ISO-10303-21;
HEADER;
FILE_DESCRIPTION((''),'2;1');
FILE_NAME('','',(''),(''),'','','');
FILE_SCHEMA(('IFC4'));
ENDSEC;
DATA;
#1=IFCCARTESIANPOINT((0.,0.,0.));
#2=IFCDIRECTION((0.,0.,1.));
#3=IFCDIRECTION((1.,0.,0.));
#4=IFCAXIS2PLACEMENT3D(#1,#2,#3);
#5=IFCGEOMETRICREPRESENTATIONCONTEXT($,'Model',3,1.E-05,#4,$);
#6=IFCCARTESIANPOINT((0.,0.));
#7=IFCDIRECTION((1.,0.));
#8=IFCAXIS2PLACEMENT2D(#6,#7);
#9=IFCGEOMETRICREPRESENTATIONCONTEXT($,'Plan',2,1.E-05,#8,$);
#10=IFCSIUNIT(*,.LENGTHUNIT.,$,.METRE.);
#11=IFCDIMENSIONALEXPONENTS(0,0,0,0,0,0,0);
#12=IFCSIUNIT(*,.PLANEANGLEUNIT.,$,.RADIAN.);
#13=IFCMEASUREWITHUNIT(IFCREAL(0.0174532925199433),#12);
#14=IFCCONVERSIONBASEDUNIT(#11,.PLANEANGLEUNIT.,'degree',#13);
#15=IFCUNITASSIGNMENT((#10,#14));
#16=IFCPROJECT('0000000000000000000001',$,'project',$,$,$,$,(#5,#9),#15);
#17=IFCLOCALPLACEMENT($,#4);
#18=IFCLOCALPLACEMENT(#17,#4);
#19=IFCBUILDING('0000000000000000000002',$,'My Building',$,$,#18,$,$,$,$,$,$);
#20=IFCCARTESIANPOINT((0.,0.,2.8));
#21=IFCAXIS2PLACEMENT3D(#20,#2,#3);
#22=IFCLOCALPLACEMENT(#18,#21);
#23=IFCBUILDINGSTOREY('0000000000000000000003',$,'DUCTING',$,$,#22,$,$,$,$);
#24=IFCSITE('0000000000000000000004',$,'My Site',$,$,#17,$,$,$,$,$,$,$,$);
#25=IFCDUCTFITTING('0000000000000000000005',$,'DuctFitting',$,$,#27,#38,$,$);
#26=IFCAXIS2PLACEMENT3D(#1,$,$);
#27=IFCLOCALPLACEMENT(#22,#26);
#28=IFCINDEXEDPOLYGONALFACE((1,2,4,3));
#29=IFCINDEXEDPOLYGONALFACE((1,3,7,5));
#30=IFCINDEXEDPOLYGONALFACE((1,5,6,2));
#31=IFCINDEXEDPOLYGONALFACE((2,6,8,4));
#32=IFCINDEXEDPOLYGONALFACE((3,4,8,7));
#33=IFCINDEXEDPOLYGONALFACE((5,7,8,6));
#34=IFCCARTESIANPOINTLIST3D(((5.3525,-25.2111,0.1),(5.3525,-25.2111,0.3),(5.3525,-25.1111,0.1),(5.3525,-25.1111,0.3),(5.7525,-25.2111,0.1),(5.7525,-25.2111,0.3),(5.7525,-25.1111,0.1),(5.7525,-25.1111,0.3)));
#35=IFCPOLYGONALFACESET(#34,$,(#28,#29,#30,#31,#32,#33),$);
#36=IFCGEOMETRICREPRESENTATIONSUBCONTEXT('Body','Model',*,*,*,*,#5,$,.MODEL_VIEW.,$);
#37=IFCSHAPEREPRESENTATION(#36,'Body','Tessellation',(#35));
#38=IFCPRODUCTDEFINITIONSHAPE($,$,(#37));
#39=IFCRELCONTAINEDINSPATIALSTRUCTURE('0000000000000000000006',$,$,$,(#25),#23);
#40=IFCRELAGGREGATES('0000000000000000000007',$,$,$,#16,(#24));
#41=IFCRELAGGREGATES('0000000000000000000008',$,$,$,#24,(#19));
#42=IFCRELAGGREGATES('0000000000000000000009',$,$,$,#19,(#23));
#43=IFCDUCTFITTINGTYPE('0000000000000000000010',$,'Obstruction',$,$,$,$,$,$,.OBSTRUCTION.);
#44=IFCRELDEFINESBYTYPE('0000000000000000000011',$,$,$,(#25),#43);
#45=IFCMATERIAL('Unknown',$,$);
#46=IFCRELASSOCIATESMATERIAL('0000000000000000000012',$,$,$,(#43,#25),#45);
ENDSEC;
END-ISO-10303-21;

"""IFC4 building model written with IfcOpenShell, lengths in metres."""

from ifc_helpers import new_model, entity, si_unit, converted_unit, frame, origin_with_axes, origin_2d_with_axis, place, context, subcontext, project, spatial, rectangle, extrude, material, material_profile, profile_set, profile_usage, type_object, element, save


model = new_model("IFC4")

# Units and contexts
model_context = context("Model", 3, precision=1e-05, world=origin_with_axes())
plan_context = context("Plan", 2, precision=1e-05, world=origin_2d_with_axis())
body_context = subcontext(model_context, "Body", "Model", "MODEL_VIEW")
ifc_project = project(units=[si_unit("LENGTHUNIT", "METRE"), converted_unit("PLANEANGLEUNIT", "degree", entity("IfcReal", 0.0174532925199433), si_unit("PLANEANGLEUNIT", "RADIAN"), dimensions=[0, 0, 0, 0, 0, 0, 0])], contexts=[model_context, plan_context])

# Site, building, storey
site_placement = place(None, origin_with_axes())
site = spatial("IfcSite", under=ifc_project, at=site_placement, Name="My Site")
building_placement = place(site_placement, origin_with_axes())
building = spatial("IfcBuilding", under=site, at=building_placement, Name="My Building")
storey_placement = place(building_placement, frame((0.0, 0.0, 2.8), z_axis=(0.0, 0.0, 1.0), x_axis=(1.0, 0.0, 0.0)))
storey = spatial("IfcBuildingStorey", under=building, at=storey_placement, Name="DUCTING")

# Shared definitions
ifc_material = material(Name="Unknown")

# Duct fitting
ifc_material_profile_1 = material_profile(ifc_material, rectangle(XDim=0.4, YDim=0.2))
ifc_profile_set_1 = profile_set([ifc_material_profile_1])
duct_fitting_type_1 = type_object("IfcDuctFittingType", Name="Obstruction", PredefinedType="OBSTRUCTION", material=ifc_profile_set_1)
ifc_profile_usage_1 = profile_usage(ifc_profile_set_1, cardinal=5)
duct_fitting_1_placement = place(storey_placement, frame((5.5525, -25.1111, 0.2), z_axis=(0.0, -1.0, 0.0), x_axis=(1.0, 0.0, 0.0)))
element("IfcDuctFitting", 1, at=duct_fitting_1_placement, inside=storey, type_object=duct_fitting_type_1, material=ifc_profile_usage_1, Name="DuctFitting", context=body_context, shape_type="SweptSolid", body=[
    extrude(rectangle(XDim=0.4, YDim=0.2), origin_with_axes(), (0.0, 0.0, 1.0), 0.1),
])

save(model, "model.ifc")
